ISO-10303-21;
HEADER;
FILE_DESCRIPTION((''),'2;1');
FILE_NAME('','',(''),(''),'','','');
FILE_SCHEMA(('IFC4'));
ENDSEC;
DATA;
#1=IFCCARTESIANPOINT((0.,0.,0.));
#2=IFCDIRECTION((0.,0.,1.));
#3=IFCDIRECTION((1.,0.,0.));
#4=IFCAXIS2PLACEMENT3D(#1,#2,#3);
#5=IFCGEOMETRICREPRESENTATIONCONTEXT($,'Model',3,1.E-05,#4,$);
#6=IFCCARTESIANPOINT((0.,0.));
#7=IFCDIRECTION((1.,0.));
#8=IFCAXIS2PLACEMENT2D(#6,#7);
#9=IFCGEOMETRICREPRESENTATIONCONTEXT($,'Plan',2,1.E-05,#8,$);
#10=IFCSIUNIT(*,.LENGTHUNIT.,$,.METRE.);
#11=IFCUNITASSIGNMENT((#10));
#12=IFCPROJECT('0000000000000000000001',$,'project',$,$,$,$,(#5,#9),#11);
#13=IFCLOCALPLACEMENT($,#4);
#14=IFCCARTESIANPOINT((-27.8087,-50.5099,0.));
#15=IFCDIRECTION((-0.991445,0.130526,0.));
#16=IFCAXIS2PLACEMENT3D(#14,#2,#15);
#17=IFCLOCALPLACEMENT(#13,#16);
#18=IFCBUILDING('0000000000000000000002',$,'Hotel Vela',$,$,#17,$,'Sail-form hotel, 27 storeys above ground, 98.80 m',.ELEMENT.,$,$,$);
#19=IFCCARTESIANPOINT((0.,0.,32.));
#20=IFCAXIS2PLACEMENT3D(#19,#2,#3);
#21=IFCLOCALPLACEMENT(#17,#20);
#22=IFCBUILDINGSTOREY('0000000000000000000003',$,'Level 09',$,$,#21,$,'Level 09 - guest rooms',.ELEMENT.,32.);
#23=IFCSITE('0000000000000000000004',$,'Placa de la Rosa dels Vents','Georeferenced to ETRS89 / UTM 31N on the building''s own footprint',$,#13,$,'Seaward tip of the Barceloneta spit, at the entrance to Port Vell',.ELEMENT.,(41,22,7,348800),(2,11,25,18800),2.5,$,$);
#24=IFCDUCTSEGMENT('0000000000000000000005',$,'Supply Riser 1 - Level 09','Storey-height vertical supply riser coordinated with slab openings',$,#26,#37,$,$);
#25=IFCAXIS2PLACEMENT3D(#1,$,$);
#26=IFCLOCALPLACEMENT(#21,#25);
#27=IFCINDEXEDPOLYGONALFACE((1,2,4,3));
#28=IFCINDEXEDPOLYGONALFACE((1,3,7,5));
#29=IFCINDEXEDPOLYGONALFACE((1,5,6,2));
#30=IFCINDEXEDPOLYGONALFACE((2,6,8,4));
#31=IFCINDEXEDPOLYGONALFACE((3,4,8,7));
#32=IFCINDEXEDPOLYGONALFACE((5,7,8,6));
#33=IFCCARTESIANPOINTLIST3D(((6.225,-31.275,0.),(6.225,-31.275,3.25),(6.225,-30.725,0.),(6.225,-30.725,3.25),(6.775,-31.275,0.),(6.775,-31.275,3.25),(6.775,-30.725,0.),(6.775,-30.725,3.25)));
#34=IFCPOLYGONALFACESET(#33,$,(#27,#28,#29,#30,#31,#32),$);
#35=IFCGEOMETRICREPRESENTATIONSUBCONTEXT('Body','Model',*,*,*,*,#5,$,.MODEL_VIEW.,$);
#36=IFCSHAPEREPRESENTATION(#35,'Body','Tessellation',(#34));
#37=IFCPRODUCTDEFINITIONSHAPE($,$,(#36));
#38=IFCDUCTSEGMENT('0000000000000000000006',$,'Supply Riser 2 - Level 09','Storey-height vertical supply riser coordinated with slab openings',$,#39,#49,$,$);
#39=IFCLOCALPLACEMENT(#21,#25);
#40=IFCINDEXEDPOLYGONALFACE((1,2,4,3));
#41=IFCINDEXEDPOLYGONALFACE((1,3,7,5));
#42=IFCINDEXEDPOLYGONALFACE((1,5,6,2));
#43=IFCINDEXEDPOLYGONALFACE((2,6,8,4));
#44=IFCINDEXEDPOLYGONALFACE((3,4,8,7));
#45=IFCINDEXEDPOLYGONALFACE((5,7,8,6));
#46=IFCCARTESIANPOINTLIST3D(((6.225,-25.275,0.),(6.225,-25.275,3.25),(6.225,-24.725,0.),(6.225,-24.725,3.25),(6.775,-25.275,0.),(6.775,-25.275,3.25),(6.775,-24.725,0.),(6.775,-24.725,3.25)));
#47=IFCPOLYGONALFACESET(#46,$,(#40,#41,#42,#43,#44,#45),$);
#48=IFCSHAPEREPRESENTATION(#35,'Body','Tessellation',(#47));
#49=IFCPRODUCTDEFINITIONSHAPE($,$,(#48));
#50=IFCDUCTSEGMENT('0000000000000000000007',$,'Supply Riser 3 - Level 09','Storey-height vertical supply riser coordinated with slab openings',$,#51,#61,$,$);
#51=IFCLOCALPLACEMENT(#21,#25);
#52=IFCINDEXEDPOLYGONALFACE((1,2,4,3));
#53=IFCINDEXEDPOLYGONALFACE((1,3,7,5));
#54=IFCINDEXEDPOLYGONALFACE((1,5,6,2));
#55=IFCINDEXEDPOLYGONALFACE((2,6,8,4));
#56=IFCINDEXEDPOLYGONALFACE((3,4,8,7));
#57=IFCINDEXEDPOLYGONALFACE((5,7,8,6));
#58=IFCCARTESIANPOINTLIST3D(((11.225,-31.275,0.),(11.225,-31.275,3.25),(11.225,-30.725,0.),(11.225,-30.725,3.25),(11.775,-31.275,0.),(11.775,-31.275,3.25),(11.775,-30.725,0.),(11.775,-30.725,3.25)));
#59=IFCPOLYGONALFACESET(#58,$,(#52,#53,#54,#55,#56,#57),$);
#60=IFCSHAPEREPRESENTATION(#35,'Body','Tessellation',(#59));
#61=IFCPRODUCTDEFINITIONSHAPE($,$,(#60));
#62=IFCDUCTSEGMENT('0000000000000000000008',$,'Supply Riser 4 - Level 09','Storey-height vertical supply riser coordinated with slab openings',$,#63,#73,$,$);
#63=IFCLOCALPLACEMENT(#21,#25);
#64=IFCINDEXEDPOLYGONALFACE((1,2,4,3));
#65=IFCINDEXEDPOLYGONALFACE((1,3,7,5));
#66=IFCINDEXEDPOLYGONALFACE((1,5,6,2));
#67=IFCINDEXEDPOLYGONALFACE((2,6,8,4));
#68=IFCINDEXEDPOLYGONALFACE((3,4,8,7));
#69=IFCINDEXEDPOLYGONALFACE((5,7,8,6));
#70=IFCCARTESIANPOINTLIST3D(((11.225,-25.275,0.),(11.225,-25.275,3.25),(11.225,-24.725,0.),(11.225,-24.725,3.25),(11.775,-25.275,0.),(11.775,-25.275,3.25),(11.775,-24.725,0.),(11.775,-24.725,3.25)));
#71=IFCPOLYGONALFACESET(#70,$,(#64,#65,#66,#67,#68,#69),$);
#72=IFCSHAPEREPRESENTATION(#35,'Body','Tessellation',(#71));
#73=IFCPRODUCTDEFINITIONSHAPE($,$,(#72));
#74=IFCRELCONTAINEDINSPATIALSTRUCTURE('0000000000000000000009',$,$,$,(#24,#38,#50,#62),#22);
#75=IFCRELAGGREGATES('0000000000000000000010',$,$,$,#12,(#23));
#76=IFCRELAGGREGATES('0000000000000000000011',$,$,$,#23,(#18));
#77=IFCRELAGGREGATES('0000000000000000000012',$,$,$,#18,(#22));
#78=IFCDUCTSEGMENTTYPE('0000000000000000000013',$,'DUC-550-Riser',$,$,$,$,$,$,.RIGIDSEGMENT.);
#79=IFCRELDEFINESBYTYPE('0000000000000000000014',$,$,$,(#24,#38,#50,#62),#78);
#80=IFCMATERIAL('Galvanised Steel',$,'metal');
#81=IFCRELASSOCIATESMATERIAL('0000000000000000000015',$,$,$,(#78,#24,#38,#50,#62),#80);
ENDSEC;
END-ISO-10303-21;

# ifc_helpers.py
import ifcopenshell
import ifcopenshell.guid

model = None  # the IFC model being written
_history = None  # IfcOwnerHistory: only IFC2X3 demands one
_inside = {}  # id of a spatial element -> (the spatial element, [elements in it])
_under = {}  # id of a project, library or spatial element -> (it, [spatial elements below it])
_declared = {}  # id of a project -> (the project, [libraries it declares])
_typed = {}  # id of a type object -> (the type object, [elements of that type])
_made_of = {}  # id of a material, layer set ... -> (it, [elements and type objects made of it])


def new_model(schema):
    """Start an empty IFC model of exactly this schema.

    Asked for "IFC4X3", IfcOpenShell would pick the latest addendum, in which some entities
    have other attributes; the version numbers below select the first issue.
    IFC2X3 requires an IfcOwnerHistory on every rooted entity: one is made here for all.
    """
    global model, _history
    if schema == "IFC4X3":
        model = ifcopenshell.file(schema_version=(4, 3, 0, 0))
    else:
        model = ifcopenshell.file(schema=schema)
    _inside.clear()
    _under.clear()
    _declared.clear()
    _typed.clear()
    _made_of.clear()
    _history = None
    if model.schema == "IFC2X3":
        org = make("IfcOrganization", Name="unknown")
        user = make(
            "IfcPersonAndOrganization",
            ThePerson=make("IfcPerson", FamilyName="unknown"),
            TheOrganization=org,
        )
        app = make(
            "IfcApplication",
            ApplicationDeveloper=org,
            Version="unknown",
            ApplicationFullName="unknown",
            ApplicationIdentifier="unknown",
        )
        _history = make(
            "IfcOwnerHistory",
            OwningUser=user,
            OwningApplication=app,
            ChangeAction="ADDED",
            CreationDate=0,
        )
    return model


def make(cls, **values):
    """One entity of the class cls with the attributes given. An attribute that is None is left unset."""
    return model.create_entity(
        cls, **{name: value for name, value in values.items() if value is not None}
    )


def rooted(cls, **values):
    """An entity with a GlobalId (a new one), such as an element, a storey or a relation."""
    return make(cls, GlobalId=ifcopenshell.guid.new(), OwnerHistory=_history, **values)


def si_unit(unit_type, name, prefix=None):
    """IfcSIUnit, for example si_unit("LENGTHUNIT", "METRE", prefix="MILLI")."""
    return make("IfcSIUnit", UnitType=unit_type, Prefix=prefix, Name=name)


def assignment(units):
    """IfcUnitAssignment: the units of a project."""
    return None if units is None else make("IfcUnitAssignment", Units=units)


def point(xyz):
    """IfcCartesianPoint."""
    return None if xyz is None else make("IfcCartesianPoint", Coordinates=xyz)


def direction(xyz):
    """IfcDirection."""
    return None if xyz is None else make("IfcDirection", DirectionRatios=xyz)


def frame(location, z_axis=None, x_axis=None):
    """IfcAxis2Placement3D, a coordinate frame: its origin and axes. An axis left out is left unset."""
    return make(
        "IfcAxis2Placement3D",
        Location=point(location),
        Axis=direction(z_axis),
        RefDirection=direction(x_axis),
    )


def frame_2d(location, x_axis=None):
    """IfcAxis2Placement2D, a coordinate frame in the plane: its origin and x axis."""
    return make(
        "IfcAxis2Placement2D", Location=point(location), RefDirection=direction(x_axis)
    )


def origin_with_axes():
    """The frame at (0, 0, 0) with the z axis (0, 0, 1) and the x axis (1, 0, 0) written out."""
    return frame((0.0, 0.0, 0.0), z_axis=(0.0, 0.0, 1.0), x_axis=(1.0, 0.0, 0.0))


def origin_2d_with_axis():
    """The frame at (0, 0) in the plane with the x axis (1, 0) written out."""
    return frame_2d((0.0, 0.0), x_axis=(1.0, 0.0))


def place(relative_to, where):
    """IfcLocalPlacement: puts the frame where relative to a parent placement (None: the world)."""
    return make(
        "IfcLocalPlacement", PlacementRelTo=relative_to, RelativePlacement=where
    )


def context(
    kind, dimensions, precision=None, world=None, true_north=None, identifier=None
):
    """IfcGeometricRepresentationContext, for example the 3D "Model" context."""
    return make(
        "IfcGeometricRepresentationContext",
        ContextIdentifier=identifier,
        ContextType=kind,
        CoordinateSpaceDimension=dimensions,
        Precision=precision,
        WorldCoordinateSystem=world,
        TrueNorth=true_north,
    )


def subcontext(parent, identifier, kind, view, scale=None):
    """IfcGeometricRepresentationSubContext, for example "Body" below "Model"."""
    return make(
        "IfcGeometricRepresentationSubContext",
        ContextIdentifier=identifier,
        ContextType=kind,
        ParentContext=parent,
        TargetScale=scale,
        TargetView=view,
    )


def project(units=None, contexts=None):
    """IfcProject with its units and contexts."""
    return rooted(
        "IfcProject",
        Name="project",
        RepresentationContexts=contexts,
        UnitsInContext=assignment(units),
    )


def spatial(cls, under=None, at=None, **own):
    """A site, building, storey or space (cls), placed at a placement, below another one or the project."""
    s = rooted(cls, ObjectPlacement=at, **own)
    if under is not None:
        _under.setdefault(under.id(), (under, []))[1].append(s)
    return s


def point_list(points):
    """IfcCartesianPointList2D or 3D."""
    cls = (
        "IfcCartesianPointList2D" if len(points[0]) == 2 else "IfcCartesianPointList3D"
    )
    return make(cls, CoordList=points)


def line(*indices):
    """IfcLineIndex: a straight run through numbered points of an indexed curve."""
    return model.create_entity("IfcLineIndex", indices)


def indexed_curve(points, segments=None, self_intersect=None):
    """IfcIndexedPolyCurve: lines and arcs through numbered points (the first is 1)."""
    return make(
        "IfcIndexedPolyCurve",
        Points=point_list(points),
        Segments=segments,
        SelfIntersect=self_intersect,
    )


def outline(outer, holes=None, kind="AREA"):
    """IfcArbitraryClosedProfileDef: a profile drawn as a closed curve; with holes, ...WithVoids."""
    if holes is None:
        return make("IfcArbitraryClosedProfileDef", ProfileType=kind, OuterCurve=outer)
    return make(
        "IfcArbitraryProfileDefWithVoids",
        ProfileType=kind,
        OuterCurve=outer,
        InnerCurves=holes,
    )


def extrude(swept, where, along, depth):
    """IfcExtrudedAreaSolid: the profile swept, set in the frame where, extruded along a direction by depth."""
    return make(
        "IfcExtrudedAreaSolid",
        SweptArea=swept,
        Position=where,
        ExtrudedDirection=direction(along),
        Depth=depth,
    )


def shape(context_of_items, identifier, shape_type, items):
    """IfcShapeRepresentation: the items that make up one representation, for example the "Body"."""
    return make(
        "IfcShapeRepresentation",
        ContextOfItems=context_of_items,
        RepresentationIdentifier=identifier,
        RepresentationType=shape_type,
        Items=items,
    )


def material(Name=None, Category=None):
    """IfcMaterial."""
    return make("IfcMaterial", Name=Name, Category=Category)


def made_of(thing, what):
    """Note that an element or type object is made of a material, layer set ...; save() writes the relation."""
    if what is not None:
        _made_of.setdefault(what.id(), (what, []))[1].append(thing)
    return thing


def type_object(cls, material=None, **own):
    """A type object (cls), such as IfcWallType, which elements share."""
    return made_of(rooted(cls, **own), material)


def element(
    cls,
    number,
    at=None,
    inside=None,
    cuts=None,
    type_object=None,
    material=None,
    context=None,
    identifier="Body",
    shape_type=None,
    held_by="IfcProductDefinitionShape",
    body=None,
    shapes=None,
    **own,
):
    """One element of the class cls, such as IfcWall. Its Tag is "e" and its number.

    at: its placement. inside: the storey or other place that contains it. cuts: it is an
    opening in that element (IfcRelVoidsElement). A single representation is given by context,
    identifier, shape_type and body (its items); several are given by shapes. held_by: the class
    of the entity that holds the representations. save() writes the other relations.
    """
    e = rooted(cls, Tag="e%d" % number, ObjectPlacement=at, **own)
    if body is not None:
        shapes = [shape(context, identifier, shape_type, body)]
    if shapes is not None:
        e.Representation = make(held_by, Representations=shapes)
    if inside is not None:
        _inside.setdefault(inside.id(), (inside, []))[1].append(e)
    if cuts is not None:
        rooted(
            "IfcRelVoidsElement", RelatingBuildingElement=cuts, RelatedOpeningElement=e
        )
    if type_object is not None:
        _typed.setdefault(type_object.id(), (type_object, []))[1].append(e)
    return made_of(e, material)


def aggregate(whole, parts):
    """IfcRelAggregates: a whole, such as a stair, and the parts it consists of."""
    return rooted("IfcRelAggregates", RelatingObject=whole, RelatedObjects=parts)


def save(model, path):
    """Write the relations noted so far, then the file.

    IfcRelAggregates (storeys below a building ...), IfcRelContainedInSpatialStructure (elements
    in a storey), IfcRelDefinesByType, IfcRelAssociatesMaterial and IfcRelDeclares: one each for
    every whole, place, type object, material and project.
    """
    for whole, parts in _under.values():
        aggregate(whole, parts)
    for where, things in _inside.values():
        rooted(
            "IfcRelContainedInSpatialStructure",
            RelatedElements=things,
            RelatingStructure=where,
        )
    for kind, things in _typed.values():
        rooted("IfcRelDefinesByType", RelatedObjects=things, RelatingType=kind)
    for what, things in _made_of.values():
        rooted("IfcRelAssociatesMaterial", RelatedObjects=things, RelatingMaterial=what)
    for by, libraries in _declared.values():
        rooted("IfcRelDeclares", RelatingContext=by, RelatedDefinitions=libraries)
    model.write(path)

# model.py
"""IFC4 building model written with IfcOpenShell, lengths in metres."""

from ifc_helpers import new_model, si_unit, frame, origin_with_axes, origin_2d_with_axis, place, context, subcontext, project, spatial, line, indexed_curve, outline, extrude, material, type_object, element, save


model = new_model("IFC4")

# Units and contexts
model_context = context("Model", 3, precision=1e-05, world=origin_with_axes())
plan_context = context("Plan", 2, precision=1e-05, world=origin_2d_with_axis())
body_context = subcontext(model_context, "Body", "Model", "MODEL_VIEW")
ifc_project = project(units=[si_unit("LENGTHUNIT", "METRE")], contexts=[model_context, plan_context])

# Site, building, storey
site_placement = place(None, origin_with_axes())
site = spatial("IfcSite", under=ifc_project, at=site_placement, Name="Placa de la Rosa dels Vents", Description="Georeferenced to ETRS89 / UTM 31N on the building's own footprint", LongName="Seaward tip of the Barceloneta spit, at the entrance to Port Vell", CompositionType="ELEMENT", RefLatitude=(41, 22, 7, 348800), RefLongitude=(2, 11, 25, 18800), RefElevation=2.5)
building_placement = place(site_placement, frame((-27.8087, -50.5099, 0.0), z_axis=(0.0, 0.0, 1.0), x_axis=(-0.991445, 0.130526, 0.0)))
building = spatial("IfcBuilding", under=site, at=building_placement, Name="Hotel Vela", LongName="Sail-form hotel, 27 storeys above ground, 98.80 m", CompositionType="ELEMENT")
storey_placement = place(building_placement, frame((0.0, 0.0, 32.0), z_axis=(0.0, 0.0, 1.0), x_axis=(1.0, 0.0, 0.0)))
storey = spatial("IfcBuildingStorey", under=building, at=storey_placement, Name="Level 09", LongName="Level 09 - guest rooms", CompositionType="ELEMENT", Elevation=32.0)

# Duct segments
ifc_material = material(Name="Galvanised Steel", Category="metal")
duct_segment_type = type_object("IfcDuctSegmentType", Name="DUC-550-Riser", PredefinedType="RIGIDSEGMENT", material=ifc_material)
for number, where, z_axis, x_axis, name in (
    (1, (6.225, -31.275, 0.0), (0.0, 0.0, 1.0), (1.0, 0.0, 0.0), "Supply Riser 1 - Level 09"),
    (2, (6.225, -25.275, 0.0), (0.0, 0.0, 1.0), (1.0, 0.0, 0.0), "Supply Riser 2 - Level 09"),
    (3, (11.225, -31.275, 0.0), (0.0, 0.0, 1.0), (1.0, 0.0, 0.0), "Supply Riser 3 - Level 09"),
    (4, (11.225, -25.275, 0.0), (0.0, 0.0, 1.0), (1.0, 0.0, 0.0), "Supply Riser 4 - Level 09"),
):
    element("IfcDuctSegment", number, at=place(storey_placement, frame(where, z_axis=z_axis, x_axis=x_axis)), inside=storey, type_object=duct_segment_type, material=ifc_material, Name=name, Description="Storey-height vertical supply riser coordinated with slab openings", context=body_context, shape_type="SweptSolid", body=[
        extrude(outline(indexed_curve([(0.0, 0.0), (0.55, 0.0), (0.55, 0.55), (0.0, 0.55)], segments=[line(1, 2, 3, 4, 1)])), origin_with_axes(), (0.0, 0.0, 1.0), 3.25),
    ])

save(model, "model.ifc")
